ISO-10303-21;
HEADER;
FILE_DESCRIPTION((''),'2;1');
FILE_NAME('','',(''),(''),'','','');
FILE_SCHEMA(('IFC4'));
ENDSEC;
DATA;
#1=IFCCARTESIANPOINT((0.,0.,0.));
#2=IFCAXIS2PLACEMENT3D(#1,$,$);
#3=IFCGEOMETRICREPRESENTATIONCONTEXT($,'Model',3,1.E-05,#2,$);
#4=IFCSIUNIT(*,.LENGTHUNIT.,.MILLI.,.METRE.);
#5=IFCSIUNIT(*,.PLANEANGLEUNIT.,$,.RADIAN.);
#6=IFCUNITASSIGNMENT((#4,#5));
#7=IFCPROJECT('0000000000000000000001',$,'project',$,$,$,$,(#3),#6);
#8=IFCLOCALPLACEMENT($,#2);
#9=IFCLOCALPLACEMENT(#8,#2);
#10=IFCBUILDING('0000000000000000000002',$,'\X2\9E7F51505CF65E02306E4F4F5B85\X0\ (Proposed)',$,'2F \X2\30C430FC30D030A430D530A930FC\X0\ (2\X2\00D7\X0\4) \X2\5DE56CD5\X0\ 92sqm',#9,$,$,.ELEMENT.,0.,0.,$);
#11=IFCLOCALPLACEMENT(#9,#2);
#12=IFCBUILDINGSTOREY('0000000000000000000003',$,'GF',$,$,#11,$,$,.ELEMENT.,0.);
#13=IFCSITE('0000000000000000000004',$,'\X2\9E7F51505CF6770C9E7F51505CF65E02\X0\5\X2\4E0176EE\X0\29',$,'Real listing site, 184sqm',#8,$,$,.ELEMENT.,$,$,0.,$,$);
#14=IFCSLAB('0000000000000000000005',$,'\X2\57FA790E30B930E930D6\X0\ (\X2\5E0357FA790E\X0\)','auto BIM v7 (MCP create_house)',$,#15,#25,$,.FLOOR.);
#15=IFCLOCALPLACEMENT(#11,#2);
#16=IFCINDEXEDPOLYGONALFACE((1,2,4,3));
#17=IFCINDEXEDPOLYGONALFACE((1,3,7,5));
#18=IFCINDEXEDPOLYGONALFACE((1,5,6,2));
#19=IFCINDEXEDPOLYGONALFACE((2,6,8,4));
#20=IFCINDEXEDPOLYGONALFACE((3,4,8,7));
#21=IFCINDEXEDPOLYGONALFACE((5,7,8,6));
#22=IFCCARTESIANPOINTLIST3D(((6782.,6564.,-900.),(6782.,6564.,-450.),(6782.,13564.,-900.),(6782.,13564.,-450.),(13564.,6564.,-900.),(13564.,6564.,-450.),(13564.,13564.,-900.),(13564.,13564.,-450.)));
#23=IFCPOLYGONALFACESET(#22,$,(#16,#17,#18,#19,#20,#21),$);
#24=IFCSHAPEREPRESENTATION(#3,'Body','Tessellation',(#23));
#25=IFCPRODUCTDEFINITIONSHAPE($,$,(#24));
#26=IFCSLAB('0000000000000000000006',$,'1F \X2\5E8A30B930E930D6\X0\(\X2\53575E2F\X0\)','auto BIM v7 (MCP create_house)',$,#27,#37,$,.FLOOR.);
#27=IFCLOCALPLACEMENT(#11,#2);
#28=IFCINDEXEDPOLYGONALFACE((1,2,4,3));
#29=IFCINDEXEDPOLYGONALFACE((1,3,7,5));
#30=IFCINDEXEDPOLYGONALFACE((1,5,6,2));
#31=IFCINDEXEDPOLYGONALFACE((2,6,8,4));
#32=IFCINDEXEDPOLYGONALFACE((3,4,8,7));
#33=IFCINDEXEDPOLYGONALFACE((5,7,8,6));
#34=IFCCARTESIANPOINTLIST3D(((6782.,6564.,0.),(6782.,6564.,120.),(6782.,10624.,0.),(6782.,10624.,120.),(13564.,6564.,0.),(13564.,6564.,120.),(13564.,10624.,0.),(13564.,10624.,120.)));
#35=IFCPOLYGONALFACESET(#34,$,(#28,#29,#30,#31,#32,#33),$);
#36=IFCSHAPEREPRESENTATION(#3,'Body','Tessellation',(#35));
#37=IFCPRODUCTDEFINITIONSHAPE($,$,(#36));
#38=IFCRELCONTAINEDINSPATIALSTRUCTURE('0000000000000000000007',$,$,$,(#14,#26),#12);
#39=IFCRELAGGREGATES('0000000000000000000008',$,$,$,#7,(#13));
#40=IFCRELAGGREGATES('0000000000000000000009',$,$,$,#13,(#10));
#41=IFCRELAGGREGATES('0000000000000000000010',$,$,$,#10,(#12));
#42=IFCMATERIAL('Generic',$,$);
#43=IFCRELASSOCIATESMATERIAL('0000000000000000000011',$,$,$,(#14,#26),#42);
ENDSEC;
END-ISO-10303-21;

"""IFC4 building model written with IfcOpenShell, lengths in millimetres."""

from ifc_helpers import new_model, si_unit, frame, frame_2d, origin, place, context, project, spatial, rectangle, extrude, material, element, save


model = new_model("IFC4")

# Units and contexts
model_context = context("Model", 3, precision=1e-05, world=origin())
ifc_project = project(units=[si_unit("LENGTHUNIT", "METRE", prefix="MILLI"), si_unit("PLANEANGLEUNIT", "RADIAN")], contexts=[model_context])

# Site, building, storey
site_placement = place(None, origin())
site = spatial("IfcSite", under=ifc_project, at=site_placement, Name="鹿児島県鹿児島市5丁目29", ObjectType="Real listing site, 184sqm", CompositionType="ELEMENT", RefElevation=0.0)
building_placement = place(site_placement, origin())
building = spatial("IfcBuilding", under=site, at=building_placement, Name="鹿児島市の住宅 (Proposed)", ObjectType="2F ツーバイフォー (2×4) 工法 92sqm", CompositionType="ELEMENT", ElevationOfRefHeight=0.0, ElevationOfTerrain=0.0)
storey_placement = place(building_placement, origin())
storey = spatial("IfcBuildingStorey", under=building, at=storey_placement, Name="GF", CompositionType="ELEMENT", Elevation=0.0)

# Slabs
ifc_material = material(Name="Generic")
slab_1_placement = place(storey_placement, frame((3391.0, 3282.0, -450.0)))
element("IfcSlab", 1, at=slab_1_placement, inside=storey, material=ifc_material, Name="基礎スラブ (布基礎)", Description="auto BIM v7 (MCP create_house)", PredefinedType="FLOOR", context=model_context, shape_type="SweptSolid", body=[
    extrude(rectangle(XDim=6782.0, YDim=7000.0, at=frame_2d((3391.0, 3500.0))), frame((3391.0, 3282.0, -450.0)), (0.0, 0.0, 1.0), 450.0),
])
slab_2_placement = place(storey_placement, frame((3391.0, 3282.0, 0.0)))
element("IfcSlab", 2, at=slab_2_placement, inside=storey, material=ifc_material, Name="1F 床スラブ(南帯)", Description="auto BIM v7 (MCP create_house)", PredefinedType="FLOOR", context=model_context, shape_type="SweptSolid", body=[
    extrude(rectangle(XDim=6782.0, YDim=4060.0, at=frame_2d((3391.0, 2030.0))), frame((3391.0, 3282.0, 0.0)), (0.0, 0.0, 1.0), 120.0),
])

save(model, "model.ifc")
